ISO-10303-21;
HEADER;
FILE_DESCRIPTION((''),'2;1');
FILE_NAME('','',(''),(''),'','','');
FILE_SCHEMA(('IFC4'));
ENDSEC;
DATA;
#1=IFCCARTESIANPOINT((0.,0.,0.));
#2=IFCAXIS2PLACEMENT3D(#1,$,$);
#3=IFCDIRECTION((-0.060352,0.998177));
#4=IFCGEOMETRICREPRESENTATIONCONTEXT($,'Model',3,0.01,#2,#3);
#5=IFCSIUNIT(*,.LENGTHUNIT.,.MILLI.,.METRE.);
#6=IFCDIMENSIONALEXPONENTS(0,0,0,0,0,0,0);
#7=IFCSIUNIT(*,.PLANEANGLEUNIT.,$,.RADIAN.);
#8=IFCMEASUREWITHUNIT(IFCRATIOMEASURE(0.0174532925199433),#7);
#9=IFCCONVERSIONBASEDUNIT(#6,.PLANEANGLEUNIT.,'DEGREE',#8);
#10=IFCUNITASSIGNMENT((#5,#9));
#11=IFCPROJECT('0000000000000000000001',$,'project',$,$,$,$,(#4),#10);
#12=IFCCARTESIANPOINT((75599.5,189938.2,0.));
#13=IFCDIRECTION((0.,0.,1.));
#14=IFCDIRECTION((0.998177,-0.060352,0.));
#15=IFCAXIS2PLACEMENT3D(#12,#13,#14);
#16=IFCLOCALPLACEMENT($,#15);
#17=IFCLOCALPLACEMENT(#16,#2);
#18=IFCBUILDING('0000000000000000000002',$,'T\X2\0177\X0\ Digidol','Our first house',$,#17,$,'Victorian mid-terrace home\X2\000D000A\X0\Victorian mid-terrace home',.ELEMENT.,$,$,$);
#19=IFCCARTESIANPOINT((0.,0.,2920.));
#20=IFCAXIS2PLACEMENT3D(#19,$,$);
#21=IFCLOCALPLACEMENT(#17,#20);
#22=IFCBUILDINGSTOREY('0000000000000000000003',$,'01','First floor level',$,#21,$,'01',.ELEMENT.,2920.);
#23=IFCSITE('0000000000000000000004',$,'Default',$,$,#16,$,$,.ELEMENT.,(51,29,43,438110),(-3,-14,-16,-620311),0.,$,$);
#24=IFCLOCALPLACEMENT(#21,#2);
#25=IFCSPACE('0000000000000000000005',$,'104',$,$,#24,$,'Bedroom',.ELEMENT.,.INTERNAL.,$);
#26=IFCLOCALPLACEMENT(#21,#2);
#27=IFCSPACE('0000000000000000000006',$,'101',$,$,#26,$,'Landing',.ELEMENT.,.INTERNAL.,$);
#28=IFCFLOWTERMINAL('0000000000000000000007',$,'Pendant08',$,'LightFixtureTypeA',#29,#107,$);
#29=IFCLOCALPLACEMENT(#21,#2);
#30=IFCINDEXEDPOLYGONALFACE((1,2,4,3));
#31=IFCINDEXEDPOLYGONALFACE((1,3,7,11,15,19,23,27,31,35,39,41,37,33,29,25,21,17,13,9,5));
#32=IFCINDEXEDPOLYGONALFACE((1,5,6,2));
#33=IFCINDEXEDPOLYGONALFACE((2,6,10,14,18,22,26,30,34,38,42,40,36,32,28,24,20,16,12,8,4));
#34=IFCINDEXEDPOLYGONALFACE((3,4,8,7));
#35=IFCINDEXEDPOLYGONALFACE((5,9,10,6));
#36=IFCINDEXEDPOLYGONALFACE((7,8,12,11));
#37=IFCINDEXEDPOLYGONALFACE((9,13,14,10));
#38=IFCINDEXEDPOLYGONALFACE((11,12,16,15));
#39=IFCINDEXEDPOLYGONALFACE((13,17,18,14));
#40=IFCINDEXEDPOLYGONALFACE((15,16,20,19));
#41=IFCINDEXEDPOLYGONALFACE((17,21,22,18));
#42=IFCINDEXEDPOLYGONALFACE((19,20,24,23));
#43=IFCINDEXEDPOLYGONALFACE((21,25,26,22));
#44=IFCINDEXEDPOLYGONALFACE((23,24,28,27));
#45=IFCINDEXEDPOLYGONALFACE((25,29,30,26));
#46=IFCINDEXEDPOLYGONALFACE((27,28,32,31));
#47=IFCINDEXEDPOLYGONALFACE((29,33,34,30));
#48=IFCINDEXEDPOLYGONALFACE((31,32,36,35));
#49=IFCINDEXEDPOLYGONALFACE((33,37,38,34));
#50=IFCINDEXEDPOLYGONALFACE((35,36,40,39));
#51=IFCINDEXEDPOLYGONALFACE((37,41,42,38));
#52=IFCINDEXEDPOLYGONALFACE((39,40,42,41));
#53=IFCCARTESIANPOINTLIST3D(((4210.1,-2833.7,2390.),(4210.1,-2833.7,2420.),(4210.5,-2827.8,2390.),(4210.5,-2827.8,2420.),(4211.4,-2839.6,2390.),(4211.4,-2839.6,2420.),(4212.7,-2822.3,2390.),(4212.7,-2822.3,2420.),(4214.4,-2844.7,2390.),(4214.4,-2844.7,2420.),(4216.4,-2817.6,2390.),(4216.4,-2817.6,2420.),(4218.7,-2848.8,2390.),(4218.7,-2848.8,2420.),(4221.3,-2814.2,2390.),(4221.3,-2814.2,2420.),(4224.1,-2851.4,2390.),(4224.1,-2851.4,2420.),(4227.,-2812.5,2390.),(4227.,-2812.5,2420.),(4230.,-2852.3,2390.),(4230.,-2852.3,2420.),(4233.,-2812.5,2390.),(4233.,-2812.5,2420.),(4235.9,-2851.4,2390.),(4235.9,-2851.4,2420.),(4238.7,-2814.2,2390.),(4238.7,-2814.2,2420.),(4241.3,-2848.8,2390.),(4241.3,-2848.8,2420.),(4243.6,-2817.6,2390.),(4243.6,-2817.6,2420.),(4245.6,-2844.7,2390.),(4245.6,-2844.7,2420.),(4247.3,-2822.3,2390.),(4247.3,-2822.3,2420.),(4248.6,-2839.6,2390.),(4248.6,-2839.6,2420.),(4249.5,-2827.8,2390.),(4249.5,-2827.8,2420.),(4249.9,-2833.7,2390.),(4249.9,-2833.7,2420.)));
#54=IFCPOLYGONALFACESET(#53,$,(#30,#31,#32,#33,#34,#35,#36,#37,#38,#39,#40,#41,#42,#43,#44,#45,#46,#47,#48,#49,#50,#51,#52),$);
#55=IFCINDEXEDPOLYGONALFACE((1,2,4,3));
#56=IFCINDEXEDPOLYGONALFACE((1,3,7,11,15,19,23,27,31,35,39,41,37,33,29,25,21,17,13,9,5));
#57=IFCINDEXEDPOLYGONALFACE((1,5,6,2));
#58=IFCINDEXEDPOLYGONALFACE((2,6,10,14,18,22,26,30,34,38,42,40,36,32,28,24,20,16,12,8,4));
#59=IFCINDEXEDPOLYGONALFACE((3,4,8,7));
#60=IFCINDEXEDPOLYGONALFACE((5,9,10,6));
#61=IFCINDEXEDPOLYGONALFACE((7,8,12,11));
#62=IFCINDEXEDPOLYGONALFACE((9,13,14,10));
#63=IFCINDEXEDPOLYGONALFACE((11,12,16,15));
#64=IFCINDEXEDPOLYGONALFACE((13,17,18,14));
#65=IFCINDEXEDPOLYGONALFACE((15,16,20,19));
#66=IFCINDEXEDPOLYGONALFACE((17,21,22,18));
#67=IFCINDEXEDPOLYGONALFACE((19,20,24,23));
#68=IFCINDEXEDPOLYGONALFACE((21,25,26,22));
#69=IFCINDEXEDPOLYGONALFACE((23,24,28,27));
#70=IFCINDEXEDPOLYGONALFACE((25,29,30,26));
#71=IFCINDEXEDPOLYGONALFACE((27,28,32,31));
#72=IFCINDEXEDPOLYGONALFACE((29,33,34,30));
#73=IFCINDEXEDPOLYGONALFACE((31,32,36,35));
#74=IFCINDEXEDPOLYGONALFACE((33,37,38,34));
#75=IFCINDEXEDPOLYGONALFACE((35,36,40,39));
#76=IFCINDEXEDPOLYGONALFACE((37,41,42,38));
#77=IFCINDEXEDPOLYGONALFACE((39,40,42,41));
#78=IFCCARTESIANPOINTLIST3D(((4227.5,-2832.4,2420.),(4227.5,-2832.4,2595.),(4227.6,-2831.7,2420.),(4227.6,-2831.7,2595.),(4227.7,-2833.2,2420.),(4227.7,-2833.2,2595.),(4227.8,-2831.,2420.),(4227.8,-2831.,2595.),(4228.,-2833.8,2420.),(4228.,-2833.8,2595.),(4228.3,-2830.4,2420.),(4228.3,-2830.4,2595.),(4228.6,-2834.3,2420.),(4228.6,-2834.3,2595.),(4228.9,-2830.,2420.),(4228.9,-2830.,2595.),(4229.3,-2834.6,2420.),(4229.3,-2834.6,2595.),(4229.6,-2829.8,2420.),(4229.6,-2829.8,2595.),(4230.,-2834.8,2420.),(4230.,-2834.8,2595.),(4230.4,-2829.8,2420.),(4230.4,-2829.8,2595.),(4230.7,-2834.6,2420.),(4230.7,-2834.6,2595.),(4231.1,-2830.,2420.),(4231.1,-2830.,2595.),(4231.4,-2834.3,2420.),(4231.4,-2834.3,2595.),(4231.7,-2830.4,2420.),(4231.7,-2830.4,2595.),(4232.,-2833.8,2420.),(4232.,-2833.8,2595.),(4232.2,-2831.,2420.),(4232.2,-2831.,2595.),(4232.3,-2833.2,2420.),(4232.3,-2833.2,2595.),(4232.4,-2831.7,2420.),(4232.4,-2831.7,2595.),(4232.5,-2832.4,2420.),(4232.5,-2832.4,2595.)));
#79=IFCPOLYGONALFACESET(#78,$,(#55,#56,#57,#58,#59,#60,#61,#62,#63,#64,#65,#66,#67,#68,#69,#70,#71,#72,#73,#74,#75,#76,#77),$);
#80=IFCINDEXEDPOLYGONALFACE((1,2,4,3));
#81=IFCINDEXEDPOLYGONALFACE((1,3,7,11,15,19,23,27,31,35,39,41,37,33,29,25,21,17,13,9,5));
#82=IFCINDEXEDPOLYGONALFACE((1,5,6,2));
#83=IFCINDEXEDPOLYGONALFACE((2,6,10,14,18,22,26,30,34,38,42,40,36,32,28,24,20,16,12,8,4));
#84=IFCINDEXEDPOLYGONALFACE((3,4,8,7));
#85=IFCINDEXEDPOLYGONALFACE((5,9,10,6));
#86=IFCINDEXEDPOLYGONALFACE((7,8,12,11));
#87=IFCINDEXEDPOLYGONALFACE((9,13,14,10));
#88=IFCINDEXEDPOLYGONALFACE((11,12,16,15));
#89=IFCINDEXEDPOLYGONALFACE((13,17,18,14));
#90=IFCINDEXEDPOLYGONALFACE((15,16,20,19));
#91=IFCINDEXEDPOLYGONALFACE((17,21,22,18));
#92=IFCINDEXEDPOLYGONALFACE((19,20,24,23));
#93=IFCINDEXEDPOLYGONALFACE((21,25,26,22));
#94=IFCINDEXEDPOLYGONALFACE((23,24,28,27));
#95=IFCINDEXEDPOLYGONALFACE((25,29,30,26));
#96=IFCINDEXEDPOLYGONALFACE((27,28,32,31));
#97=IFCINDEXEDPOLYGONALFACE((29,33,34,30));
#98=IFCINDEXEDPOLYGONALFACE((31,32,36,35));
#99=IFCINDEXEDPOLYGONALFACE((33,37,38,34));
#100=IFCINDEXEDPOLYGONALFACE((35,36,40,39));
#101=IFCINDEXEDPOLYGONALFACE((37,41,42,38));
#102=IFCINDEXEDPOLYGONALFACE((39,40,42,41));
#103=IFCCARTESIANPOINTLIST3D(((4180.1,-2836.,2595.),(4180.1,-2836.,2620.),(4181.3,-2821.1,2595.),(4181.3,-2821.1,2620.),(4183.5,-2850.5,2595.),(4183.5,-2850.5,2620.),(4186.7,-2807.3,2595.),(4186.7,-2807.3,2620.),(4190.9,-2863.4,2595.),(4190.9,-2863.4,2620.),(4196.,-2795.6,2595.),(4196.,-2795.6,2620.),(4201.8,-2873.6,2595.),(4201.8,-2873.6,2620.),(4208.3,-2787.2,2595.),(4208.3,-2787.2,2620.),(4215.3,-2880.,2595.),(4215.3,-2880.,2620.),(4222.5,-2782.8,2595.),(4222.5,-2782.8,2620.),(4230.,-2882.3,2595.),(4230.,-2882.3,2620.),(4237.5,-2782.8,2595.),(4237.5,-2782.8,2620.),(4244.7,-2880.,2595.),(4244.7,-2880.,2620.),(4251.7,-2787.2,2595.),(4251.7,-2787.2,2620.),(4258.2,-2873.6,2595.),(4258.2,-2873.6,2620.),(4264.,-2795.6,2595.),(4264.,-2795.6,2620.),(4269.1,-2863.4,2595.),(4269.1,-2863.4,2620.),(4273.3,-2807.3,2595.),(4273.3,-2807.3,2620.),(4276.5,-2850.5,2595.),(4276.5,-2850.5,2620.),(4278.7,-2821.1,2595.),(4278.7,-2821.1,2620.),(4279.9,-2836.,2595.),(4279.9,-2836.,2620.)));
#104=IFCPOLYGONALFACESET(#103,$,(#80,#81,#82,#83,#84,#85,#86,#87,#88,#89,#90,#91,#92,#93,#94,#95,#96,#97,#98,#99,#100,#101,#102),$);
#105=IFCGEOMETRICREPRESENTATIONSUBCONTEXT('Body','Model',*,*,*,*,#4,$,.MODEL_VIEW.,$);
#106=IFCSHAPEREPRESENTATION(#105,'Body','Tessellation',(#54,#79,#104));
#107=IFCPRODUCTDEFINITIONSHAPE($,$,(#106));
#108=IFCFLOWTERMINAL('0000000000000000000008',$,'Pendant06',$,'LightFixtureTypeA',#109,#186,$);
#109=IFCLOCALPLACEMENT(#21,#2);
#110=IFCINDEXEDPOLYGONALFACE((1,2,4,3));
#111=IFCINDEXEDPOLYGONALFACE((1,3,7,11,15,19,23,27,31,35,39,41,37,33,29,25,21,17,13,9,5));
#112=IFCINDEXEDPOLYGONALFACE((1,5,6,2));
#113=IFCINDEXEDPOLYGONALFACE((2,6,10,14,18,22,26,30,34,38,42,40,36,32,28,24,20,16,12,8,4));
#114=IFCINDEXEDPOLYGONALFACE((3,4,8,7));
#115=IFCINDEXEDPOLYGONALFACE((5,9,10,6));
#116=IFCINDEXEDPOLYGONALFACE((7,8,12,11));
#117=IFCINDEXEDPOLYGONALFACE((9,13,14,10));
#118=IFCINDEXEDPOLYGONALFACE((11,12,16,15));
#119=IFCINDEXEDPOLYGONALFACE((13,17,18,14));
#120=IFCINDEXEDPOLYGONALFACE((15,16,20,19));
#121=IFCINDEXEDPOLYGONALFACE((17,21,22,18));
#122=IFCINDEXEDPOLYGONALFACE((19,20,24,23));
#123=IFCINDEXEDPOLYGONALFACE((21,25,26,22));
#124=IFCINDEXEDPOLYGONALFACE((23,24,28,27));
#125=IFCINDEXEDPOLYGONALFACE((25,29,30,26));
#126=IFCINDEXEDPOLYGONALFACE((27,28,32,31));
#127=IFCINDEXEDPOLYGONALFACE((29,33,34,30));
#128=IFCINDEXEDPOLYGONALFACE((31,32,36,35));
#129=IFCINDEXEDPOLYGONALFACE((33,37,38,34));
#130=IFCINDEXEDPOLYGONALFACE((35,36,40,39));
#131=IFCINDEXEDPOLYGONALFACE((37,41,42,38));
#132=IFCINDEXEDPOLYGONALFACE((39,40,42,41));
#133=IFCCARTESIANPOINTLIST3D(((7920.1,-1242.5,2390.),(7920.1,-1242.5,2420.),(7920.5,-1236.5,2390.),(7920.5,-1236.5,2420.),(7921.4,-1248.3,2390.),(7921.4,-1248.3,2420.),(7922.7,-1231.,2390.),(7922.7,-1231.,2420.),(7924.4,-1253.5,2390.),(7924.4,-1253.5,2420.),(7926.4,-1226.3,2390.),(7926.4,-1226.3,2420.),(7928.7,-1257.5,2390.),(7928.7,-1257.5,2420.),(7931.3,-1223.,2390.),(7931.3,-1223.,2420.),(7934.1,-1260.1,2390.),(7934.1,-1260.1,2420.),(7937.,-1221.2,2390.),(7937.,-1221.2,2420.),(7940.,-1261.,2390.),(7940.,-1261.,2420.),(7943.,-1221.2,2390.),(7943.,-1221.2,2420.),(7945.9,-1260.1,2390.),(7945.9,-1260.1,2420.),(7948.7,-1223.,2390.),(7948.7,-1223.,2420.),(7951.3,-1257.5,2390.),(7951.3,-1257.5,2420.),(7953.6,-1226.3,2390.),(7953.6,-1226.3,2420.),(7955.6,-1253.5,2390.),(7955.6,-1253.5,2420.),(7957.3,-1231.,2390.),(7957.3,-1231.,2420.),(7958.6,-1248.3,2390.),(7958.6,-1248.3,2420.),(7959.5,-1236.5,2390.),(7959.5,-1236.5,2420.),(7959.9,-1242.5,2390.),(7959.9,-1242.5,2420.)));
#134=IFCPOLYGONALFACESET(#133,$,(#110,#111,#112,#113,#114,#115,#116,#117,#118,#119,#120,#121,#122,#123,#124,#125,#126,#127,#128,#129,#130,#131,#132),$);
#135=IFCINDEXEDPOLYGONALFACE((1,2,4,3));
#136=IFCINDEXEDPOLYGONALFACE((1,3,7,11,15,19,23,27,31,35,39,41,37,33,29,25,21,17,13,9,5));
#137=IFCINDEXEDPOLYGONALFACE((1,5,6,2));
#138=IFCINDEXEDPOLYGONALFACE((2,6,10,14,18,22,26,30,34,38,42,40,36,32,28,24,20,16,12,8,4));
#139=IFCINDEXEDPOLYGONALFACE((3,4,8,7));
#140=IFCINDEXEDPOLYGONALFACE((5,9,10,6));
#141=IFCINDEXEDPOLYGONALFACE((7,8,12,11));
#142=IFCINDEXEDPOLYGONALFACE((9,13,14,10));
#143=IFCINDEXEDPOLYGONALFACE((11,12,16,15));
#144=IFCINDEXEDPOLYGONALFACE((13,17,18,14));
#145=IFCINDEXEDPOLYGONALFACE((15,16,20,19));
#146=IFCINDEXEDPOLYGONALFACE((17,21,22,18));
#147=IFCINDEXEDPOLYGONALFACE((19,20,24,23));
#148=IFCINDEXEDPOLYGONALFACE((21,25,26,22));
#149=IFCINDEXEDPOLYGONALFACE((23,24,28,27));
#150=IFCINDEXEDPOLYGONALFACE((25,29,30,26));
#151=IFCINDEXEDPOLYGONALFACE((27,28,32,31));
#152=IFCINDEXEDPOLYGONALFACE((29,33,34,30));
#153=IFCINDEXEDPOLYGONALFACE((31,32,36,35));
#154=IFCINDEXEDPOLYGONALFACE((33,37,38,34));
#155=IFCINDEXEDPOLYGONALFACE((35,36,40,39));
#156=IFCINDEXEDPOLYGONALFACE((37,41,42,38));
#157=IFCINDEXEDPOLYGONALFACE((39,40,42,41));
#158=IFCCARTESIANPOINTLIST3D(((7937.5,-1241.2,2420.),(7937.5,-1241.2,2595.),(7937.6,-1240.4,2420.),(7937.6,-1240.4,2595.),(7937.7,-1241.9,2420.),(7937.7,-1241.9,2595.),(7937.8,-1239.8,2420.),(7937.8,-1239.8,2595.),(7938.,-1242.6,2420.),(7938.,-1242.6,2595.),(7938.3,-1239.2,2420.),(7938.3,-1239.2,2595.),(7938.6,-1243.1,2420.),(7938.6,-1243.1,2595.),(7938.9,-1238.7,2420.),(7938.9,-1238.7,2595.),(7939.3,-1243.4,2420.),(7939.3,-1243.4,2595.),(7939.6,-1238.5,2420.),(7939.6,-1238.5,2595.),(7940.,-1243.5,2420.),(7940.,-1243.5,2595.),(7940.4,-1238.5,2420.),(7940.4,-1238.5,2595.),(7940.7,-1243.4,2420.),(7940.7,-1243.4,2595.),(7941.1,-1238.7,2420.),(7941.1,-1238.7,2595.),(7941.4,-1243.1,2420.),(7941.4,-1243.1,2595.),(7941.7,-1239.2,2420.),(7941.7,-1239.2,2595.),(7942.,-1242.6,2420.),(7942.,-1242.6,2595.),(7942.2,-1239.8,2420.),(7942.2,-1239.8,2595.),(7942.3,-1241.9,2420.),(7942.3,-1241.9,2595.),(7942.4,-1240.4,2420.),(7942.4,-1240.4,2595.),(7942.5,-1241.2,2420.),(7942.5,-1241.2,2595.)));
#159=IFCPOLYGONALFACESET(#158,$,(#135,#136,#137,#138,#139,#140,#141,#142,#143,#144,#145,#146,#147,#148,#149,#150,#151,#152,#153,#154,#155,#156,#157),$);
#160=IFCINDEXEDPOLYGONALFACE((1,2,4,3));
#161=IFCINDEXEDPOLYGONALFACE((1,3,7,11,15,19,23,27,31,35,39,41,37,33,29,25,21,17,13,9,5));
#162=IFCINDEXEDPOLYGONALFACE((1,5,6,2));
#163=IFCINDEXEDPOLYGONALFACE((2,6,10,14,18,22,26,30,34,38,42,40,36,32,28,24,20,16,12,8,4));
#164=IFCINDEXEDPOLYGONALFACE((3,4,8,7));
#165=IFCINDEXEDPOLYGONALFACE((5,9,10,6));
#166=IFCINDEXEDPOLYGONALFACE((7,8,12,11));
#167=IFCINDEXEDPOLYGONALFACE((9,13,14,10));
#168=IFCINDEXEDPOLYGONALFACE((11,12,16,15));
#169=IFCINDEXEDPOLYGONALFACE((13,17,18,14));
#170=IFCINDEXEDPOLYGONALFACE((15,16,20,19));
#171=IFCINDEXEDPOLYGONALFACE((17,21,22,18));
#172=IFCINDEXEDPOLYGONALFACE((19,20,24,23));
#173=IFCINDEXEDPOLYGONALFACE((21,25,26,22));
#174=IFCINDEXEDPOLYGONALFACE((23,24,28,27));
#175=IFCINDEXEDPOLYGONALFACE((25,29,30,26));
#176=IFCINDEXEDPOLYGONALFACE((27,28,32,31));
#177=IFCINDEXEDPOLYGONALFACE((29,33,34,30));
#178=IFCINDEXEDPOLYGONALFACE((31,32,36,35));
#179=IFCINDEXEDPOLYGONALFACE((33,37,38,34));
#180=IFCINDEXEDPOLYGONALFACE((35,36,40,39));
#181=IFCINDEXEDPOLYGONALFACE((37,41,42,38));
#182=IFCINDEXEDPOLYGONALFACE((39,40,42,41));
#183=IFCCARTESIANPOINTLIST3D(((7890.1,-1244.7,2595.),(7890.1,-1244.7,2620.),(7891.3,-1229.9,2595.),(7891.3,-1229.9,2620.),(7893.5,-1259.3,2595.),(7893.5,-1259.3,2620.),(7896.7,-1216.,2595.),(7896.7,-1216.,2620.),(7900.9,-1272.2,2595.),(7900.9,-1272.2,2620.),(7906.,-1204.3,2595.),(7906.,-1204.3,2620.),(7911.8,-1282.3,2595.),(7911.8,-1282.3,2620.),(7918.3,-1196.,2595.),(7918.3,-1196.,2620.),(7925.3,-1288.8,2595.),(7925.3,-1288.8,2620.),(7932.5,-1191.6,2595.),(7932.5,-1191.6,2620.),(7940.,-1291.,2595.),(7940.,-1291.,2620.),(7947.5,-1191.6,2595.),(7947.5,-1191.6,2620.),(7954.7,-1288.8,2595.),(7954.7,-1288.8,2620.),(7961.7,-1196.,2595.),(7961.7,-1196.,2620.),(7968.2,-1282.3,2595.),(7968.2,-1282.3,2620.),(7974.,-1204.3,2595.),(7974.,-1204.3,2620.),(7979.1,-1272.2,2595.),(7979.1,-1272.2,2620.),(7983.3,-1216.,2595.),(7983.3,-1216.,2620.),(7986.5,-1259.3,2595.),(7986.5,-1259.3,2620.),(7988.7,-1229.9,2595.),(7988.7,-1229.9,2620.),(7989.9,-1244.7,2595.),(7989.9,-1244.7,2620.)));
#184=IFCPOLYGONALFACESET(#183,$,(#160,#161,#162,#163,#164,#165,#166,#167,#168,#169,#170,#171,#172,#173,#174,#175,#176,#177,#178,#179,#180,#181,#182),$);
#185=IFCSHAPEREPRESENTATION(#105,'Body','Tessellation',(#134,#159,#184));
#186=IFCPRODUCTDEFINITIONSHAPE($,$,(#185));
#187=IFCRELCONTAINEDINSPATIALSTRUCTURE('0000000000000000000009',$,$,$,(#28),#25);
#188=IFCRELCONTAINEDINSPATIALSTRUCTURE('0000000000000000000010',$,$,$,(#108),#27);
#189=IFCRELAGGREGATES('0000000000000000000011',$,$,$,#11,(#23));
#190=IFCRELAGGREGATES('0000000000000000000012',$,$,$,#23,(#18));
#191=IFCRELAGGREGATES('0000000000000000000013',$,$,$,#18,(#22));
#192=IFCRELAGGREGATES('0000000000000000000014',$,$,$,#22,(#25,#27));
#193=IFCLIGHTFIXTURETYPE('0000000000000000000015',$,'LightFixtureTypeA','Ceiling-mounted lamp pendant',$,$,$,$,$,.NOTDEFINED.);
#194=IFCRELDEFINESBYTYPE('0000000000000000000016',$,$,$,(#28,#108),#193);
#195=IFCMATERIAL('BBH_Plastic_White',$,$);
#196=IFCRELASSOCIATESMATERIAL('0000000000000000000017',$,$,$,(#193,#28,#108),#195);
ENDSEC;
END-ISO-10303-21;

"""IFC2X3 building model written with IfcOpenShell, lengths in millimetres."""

from ifc_helpers import new_model, entity, si_unit, converted_unit, direction, frame, frame_2d, origin, place, context, subcontext, project, spatial, circle, extrude, source, transform, mapped, material, type_object, type_shapes, element, save


model = new_model("IFC2X3")

# Units and contexts
model_context = context("Model", 3, precision=0.01, world=origin(), true_north=direction((-0.060352, 0.998177)))
body_context = subcontext(model_context, "Body", "Model", "MODEL_VIEW")
ifc_project = project(units=[si_unit("LENGTHUNIT", "METRE", prefix="MILLI"), converted_unit("PLANEANGLEUNIT", "DEGREE", entity("IfcRatioMeasure", 0.0174532925199433), si_unit("PLANEANGLEUNIT", "RADIAN"), dimensions=[0, 0, 0, 0, 0, 0, 0])], contexts=[model_context])

# Site, building, storey, space
site_placement = place(None, frame((75599.5, 189938.2, 0.0), z_axis=(0.0, 0.0, 1.0), x_axis=(0.998177, -0.060352, 0.0)))
site = spatial("IfcSite", under=ifc_project, at=site_placement, Name="Default", CompositionType="ELEMENT", RefLatitude=(51, 29, 43, 438110), RefLongitude=(-3, -14, -16, -620311), RefElevation=0.0)
building_placement = place(site_placement, origin())
building = spatial("IfcBuilding", under=site, at=building_placement, Name="Tŷ Digidol", Description="Our first house", LongName="Victorian mid-terrace home\r\nVictorian mid-terrace home", CompositionType="ELEMENT")
storey_placement = place(building_placement, frame((0.0, 0.0, 2920.0)))
storey = spatial("IfcBuildingStorey", under=building, at=storey_placement, Name="01", Description="First floor level", LongName="01", CompositionType="ELEMENT", Elevation=2920.0)
space_1_placement = place(storey_placement, origin())
space_1 = spatial("IfcSpace", under=storey, at=space_1_placement, Name="104", LongName="Bedroom", CompositionType="ELEMENT", InteriorOrExteriorSpace="INTERNAL")

# Flow terminal
ifc_material = material(Name="BBH_Plastic_White")
light_fixture_type_1 = type_object("IfcLightFixtureType", Name="LightFixtureTypeA", Description="Ceiling-mounted lamp pendant", PredefinedType="NOTDEFINED", material=ifc_material)
shared_shape_1 = source(origin(), body_context, "Body", "SweptSolid", [
    extrude(circle(Radius=20.0, at=frame_2d((0.0, 0.0), x_axis=(1.0, 0.0))), frame((0.0, 0.0, 200.0)), (0.0, 0.0, 1.0), 30.0),
    extrude(circle(Radius=2.5, at=frame_2d((0.0, 0.0), x_axis=(1.0, 0.0))), frame((0.0, 0.0, 25.0)), (0.0, 0.0, 1.0), 175.0),
    extrude(circle(Radius=50.0, at=frame_2d((0.0, 0.0), x_axis=(1.0, 0.0))), origin(), (0.0, 0.0, 1.0), 25.0),
])
type_shapes(light_fixture_type_1, [shared_shape_1])
flow_terminal_1_placement = place(space_1_placement, frame((4230.0, -2832.3, 2620.0), z_axis=(0.0, 0.0, -1.0), x_axis=(0.0, -1.0, 0.0)))
element("IfcFlowTerminal", 1, at=flow_terminal_1_placement, inside=space_1, type_object=light_fixture_type_1, material=ifc_material, Name="Pendant08", ObjectType="LightFixtureTypeA", context=body_context, shape_type="MappedRepresentation", body=[
    mapped(shared_shape_1, transform((0.0, 0.0, 0.0), scale=1.0)),
])

# Shared definitions
space_2_placement = place(storey_placement, origin())
space_2 = spatial("IfcSpace", under=storey, at=space_2_placement, Name="101", LongName="Landing", CompositionType="ELEMENT", InteriorOrExteriorSpace="INTERNAL")

# Flow terminal
flow_terminal_2_placement = place(space_2_placement, frame((7940.0, -1241.0, 2620.0), z_axis=(0.0, 0.0, -1.0), x_axis=(0.0, -1.0, 0.0)))
element("IfcFlowTerminal", 2, at=flow_terminal_2_placement, inside=space_2, type_object=light_fixture_type_1, material=ifc_material, Name="Pendant06", ObjectType="LightFixtureTypeA", context=body_context, shape_type="MappedRepresentation", body=[
    mapped(shared_shape_1, transform((0.0, 0.0, 0.0), scale=1.0)),
])

save(model, "model.ifc")
